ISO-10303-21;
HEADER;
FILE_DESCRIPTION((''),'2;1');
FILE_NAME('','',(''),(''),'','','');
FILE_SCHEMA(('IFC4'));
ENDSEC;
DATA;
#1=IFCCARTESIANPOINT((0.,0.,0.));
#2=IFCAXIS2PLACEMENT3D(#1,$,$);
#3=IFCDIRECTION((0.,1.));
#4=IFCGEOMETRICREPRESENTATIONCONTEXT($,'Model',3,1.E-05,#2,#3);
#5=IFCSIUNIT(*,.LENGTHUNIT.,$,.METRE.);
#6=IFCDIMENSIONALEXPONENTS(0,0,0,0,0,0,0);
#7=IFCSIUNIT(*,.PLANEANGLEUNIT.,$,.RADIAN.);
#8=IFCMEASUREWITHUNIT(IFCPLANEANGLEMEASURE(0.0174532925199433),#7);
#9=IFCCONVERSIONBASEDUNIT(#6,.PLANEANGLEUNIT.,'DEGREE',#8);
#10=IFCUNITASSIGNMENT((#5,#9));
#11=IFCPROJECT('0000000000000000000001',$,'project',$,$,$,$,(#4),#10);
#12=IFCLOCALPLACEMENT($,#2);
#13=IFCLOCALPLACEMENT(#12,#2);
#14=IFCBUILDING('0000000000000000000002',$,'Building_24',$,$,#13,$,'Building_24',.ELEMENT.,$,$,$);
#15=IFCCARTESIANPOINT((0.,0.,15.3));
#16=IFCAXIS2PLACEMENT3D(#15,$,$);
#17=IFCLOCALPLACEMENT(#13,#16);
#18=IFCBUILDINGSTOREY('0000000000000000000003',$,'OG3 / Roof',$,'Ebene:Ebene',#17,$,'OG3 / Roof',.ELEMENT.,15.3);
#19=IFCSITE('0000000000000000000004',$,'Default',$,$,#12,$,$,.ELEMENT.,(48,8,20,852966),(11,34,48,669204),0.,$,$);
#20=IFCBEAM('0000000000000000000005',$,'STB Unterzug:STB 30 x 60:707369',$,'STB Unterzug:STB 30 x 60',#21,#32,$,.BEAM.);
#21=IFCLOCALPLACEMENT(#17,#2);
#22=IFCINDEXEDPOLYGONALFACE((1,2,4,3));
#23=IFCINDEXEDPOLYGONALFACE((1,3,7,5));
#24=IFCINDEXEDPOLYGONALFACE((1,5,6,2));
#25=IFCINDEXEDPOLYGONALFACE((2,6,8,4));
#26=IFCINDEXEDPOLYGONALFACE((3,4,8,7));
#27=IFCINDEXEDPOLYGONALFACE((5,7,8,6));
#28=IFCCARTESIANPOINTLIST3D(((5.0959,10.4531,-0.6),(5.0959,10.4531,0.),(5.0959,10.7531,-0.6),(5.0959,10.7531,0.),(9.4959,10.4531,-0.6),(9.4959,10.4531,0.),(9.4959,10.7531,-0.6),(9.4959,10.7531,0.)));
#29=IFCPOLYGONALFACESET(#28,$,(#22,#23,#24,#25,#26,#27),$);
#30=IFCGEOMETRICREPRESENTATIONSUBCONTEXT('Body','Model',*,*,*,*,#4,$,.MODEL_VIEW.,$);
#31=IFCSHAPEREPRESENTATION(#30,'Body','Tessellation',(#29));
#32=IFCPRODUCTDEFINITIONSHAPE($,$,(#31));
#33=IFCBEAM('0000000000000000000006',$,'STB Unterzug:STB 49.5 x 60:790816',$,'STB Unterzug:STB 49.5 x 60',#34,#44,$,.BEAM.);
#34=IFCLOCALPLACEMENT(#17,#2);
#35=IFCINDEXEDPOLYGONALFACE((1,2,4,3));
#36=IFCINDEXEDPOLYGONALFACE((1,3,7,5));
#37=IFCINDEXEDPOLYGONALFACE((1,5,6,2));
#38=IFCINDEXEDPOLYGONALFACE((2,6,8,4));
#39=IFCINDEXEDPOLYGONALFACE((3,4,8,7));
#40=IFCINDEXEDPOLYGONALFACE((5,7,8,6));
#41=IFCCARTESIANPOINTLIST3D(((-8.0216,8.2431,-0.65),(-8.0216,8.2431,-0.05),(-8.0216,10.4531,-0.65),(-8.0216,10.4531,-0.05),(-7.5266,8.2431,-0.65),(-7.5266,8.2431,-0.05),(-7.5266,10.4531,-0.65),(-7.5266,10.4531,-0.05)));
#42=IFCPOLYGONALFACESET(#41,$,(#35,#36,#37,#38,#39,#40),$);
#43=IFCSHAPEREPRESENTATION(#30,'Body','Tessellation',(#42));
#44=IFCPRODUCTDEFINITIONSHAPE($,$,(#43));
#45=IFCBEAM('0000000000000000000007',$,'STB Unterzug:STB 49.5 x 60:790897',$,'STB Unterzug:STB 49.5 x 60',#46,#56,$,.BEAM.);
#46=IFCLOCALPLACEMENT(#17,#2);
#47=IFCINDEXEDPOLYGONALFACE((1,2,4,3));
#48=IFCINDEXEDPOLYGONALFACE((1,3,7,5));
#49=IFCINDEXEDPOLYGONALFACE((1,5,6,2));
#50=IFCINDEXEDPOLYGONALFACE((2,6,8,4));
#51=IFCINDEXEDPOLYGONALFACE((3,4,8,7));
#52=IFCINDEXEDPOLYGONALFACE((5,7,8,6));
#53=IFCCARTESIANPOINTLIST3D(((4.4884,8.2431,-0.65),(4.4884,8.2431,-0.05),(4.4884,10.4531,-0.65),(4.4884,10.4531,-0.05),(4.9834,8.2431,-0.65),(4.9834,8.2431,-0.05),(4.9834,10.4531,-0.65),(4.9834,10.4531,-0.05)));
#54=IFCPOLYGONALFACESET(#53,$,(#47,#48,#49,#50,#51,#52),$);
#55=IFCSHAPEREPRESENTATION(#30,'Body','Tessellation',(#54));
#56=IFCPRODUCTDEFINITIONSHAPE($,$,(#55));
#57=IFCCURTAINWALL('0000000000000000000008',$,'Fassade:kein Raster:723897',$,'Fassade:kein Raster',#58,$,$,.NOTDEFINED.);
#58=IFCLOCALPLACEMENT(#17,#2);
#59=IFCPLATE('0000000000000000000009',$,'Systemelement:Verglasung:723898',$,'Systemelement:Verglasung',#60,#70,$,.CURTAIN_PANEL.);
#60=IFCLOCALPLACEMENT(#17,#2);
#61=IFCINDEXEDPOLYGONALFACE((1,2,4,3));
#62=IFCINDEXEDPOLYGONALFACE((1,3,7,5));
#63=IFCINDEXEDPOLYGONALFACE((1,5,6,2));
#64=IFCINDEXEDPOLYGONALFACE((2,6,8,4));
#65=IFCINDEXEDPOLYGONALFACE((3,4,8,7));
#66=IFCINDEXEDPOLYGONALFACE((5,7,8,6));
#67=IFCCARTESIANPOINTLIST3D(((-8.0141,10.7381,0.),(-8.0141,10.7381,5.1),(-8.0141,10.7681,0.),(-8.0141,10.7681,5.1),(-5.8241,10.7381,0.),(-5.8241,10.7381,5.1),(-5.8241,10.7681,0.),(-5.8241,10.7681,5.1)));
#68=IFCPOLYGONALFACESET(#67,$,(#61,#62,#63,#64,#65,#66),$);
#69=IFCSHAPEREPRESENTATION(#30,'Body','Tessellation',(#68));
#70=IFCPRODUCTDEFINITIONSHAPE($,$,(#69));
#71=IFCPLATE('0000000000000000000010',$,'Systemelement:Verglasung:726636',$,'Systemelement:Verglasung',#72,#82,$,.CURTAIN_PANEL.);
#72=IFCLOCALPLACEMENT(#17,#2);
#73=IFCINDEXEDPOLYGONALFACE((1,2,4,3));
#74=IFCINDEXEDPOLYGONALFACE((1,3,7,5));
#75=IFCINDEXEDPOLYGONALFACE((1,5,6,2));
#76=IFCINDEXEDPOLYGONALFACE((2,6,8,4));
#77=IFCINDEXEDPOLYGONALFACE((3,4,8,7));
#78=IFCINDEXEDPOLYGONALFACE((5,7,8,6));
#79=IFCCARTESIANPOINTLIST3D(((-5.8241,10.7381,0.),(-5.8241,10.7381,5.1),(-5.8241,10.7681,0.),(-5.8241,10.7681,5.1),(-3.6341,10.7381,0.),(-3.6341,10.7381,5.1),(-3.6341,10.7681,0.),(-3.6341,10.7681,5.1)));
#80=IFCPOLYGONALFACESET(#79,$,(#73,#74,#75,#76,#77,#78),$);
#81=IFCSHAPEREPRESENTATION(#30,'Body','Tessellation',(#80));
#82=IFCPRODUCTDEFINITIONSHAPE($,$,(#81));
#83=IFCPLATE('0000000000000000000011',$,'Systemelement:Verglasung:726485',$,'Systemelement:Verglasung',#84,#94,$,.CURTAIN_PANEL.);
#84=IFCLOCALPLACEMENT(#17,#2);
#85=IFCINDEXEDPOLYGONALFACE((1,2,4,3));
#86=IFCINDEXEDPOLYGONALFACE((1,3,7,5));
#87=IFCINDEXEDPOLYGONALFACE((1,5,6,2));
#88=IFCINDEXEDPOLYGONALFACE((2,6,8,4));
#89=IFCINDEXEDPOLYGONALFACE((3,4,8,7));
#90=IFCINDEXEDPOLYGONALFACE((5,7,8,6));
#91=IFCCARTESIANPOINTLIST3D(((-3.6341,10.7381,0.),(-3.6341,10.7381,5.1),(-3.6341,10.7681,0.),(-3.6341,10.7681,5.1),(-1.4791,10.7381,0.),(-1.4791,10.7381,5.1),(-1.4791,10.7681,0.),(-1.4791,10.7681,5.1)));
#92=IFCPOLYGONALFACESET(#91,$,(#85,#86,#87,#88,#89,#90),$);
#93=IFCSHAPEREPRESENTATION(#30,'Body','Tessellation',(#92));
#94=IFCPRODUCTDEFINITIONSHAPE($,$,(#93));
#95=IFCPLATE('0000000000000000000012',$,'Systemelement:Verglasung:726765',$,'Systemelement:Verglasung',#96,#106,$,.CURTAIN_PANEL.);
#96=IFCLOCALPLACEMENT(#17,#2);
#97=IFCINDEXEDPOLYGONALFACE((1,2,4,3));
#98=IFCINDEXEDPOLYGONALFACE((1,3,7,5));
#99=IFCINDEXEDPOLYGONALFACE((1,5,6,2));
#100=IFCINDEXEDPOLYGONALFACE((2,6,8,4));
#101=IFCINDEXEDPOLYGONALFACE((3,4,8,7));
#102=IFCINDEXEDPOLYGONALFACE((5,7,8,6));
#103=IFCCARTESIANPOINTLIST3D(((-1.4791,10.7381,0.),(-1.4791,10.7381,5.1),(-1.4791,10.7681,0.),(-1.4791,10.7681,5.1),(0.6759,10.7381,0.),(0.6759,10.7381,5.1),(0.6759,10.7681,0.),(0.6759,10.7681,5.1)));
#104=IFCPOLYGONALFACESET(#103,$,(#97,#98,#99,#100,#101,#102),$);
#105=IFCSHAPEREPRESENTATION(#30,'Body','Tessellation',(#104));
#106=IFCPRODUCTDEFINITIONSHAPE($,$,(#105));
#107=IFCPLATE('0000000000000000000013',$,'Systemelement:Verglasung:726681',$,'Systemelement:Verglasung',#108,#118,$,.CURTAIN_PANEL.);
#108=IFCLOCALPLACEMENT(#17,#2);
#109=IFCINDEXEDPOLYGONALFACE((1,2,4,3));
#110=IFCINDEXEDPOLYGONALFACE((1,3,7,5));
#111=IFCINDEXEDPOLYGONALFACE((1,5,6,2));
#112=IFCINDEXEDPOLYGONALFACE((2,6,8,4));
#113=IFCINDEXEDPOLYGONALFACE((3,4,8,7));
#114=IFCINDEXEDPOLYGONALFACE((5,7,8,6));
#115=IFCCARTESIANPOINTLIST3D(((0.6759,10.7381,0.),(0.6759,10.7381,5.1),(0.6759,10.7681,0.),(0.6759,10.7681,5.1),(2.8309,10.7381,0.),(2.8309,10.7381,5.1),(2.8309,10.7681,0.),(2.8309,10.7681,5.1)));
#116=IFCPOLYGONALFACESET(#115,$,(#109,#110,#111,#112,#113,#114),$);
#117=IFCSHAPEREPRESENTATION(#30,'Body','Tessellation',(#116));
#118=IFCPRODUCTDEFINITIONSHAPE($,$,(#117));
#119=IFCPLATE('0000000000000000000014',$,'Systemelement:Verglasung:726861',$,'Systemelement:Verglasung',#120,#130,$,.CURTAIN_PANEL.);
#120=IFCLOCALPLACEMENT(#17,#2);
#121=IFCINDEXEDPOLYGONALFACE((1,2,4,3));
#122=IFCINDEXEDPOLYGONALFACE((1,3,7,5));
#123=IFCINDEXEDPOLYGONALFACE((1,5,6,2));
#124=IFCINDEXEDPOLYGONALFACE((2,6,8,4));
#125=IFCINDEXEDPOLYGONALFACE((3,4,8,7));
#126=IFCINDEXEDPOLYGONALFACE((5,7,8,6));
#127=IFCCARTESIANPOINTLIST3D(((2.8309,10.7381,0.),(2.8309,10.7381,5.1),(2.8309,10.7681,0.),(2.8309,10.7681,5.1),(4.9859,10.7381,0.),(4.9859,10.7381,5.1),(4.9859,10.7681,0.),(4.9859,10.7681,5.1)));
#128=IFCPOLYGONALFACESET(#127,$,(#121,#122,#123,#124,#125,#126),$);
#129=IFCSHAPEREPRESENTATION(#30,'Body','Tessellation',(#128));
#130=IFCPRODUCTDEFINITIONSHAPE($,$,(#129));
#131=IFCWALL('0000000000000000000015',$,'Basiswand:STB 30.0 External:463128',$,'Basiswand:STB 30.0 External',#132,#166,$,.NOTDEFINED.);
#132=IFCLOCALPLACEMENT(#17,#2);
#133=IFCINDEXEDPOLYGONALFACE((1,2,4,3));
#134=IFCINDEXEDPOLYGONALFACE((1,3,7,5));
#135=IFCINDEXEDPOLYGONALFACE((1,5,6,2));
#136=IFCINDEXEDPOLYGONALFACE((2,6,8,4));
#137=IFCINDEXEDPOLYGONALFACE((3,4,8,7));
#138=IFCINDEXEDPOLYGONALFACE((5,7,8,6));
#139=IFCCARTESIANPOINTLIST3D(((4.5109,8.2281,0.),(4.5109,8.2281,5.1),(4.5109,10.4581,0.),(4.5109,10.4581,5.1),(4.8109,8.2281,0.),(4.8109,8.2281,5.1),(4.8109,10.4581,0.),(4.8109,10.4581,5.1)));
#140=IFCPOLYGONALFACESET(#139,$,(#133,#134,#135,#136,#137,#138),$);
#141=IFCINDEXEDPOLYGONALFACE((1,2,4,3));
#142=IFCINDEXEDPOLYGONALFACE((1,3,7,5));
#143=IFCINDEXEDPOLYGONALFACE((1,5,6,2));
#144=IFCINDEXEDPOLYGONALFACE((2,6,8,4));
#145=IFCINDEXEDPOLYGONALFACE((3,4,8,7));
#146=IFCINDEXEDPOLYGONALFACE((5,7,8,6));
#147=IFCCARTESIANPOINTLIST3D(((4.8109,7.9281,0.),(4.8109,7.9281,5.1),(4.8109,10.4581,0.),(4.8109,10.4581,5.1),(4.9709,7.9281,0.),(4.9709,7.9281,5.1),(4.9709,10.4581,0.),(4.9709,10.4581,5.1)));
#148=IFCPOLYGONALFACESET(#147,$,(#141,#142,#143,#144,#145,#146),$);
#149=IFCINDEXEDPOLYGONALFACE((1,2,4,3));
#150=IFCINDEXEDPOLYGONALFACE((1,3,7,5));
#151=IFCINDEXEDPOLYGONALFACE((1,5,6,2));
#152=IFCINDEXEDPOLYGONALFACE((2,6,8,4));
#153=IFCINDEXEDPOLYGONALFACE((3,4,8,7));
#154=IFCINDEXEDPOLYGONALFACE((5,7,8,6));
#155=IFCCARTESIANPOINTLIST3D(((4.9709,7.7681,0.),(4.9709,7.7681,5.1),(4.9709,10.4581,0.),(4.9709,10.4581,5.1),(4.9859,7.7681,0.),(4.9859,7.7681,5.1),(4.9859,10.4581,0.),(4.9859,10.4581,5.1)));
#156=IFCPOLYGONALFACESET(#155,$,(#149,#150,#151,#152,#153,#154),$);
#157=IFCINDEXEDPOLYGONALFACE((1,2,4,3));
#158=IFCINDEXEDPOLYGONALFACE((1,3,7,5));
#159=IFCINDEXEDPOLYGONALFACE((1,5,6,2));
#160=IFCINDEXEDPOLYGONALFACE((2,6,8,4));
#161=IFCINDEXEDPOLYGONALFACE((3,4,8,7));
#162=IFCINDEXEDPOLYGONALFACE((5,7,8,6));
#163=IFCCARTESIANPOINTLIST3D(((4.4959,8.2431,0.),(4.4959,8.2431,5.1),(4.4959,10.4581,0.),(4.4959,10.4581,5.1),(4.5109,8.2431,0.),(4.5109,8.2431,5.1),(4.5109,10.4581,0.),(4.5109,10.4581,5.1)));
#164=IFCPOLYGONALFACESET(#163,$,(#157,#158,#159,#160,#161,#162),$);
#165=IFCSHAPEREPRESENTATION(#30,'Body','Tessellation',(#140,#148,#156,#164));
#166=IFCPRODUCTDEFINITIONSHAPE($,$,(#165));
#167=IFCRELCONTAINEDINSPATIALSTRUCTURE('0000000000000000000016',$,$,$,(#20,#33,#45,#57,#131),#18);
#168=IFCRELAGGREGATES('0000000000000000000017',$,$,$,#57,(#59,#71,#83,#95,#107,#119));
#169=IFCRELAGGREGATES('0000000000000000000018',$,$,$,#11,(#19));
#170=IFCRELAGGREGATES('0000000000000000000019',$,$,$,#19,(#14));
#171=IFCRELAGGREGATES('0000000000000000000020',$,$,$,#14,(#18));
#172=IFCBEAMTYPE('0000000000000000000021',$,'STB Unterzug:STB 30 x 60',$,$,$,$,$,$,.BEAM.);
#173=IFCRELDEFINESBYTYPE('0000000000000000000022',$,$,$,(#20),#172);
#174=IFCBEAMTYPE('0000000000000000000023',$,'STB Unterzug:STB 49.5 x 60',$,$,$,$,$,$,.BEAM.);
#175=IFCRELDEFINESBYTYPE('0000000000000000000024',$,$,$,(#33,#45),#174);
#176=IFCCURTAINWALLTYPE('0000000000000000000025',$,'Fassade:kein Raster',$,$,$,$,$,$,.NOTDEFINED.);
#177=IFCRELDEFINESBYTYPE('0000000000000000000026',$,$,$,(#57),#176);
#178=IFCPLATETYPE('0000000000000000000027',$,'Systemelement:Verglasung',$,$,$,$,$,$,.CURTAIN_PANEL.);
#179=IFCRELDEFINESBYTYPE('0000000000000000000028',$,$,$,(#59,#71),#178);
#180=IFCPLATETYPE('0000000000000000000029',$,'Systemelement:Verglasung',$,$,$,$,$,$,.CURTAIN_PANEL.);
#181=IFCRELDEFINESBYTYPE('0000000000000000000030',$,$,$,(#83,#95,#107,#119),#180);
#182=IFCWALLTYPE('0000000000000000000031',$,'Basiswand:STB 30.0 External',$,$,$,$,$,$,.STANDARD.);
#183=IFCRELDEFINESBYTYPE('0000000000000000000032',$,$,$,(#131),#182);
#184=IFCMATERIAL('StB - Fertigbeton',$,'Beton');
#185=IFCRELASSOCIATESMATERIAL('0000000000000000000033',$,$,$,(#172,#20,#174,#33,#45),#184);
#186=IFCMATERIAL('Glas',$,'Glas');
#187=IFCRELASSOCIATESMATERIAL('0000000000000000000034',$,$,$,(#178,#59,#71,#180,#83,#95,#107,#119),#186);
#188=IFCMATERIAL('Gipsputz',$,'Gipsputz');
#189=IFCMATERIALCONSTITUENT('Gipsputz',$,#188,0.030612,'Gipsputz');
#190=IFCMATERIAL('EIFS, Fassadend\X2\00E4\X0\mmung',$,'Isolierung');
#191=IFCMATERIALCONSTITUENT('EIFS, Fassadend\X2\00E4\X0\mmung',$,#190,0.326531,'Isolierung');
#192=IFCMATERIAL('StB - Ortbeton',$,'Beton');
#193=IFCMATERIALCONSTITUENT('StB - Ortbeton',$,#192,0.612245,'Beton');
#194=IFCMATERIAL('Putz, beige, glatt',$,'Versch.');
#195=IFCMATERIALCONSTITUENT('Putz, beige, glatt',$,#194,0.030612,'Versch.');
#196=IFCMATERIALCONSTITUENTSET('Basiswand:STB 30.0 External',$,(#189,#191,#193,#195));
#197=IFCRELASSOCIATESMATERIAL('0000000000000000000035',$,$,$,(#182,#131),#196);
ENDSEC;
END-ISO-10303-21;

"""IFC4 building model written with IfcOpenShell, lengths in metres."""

from ifc_helpers import new_model, entity, si_unit, converted_unit, direction, frame, origin, place, context, subcontext, project, spatial, indexed_curve, outline, extrude, source, transform, mapped, material, constituent, constituent_set, type_object, type_shapes, element, aggregate, save


model = new_model("IFC4")

# Units and contexts
model_context = context("Model", 3, precision=1e-05, world=origin(), true_north=direction((0.0, 1.0)))
body_context = subcontext(model_context, "Body", "Model", "MODEL_VIEW")
ifc_project = project(units=[si_unit("LENGTHUNIT", "METRE"), converted_unit("PLANEANGLEUNIT", "DEGREE", entity("IfcPlaneAngleMeasure", 0.0174532925199433), si_unit("PLANEANGLEUNIT", "RADIAN"), dimensions=[0, 0, 0, 0, 0, 0, 0])], contexts=[model_context])

# Site, building, storey
site_placement = place(None, origin())
site = spatial("IfcSite", under=ifc_project, at=site_placement, Name="Default", CompositionType="ELEMENT", RefLatitude=(48, 8, 20, 852966), RefLongitude=(11, 34, 48, 669204), RefElevation=0.0)
building_placement = place(site_placement, origin())
building = spatial("IfcBuilding", under=site, at=building_placement, Name="Building_24", LongName="Building_24", CompositionType="ELEMENT")
storey_placement = place(building_placement, frame((0.0, 0.0, 15.3)))
storey = spatial("IfcBuildingStorey", under=building, at=storey_placement, Name="OG3 / Roof", ObjectType="Ebene:Ebene", LongName="OG3 / Roof", CompositionType="ELEMENT", Elevation=15.3)

# Shared definitions
ifc_material_1 = material(Name="StB - Ortbeton", Category="Beton")

# Beams
ifc_material_2 = material(Name="StB - Fertigbeton", Category="Beton")
beam_type_1 = type_object("IfcBeamType", Name="STB Unterzug:STB 30 x 60", PredefinedType="BEAM", material=ifc_material_2)
shared_shape_1 = source(origin(), body_context, "Body", "SweptSolid", [
    extrude(outline(indexed_curve([(-2.2, -0.15), (2.2, -0.15), (2.2, 0.15), (-2.2, 0.15), (-2.2, -0.15)], self_intersect=False)), frame((-0.11, 0.0, -0.3), z_axis=(0.0, 0.0, 1.0), x_axis=(-1.0, 0.0, 0.0)), (0.0, 0.0, 1.0), 0.6),
])
type_shapes(beam_type_1, [shared_shape_1])
beam_1_placement = place(storey_placement, frame((7.4059, 10.6031, -0.3)))
element("IfcBeam", 1, at=beam_1_placement, inside=storey, type_object=beam_type_1, material=ifc_material_2, Name="STB Unterzug:STB 30 x 60:707369", ObjectType="STB Unterzug:STB 30 x 60", PredefinedType="BEAM", context=body_context, shape_type="MappedRepresentation", body=[
    mapped(shared_shape_1, transform((0.0, 0.0, 0.0), scale=1.0)),
])
beam_type_2 = type_object("IfcBeamType", Name="STB Unterzug:STB 49.5 x 60", PredefinedType="BEAM", material=ifc_material_2)
shared_shape_2 = source(origin(), body_context, "Body", "SweptSolid", [
    extrude(outline(indexed_curve([(-1.105, -0.2475), (1.105, -0.2475), (1.105, 0.2475), (-1.105, 0.2475), (-1.105, -0.2475)], self_intersect=False)), frame((-0.0475, 0.0, -0.3), z_axis=(0.0, 0.0, 1.0), x_axis=(-1.0, 0.0, 0.0)), (0.0, 0.0, 1.0), 0.6),
])
type_shapes(beam_type_2, [shared_shape_2])
for number, where, z_axis, x_axis, name in (
    (2, (-7.7741, 9.3006, -0.35), (0.0, 0.0, 1.0), (0.0, -1.0, 0.0), "STB Unterzug:STB 49.5 x 60:790816"),
    (3, (4.7359, 9.3006, -0.35), (0.0, 0.0, 1.0), (0.0, -1.0, 0.0), "STB Unterzug:STB 49.5 x 60:790897"),
):
    element("IfcBeam", number, at=place(storey_placement, frame(where, z_axis=z_axis, x_axis=x_axis)), inside=storey, type_object=beam_type_2, material=ifc_material_2, Name=name, ObjectType="STB Unterzug:STB 49.5 x 60", PredefinedType="BEAM", context=body_context, shape_type="MappedRepresentation", body=[
        mapped(shared_shape_2, transform((0.0, 0.0, 0.0), scale=1.0)),
    ])

# Curtain wall, plates
curtain_wall_type = type_object("IfcCurtainWallType", Name="Fassade:kein Raster", PredefinedType="NOTDEFINED")
curtain_wall_placement = place(storey_placement, frame((0.0, 0.0, -15.3)))
curtain_wall = element("IfcCurtainWall", 4, at=curtain_wall_placement, inside=storey, type_object=curtain_wall_type, Name="Fassade:kein Raster:723897", ObjectType="Fassade:kein Raster", PredefinedType="NOTDEFINED")
ifc_material_3 = material(Name="Glas", Category="Glas")
plate_type_1 = type_object("IfcPlateType", Name="Systemelement:Verglasung", PredefinedType="CURTAIN_PANEL", material=ifc_material_3)
shared_shape_3 = source(origin(), body_context, "Body", "SweptSolid", [
    extrude(outline(indexed_curve([(-0.015, -1.095), (0.015, -1.095), (0.015, 1.095), (-0.015, 1.095), (-0.015, -1.095)], self_intersect=False)), frame((0.0, 0.0, 0.0), z_axis=(0.0, 0.0, 1.0), x_axis=(0.0, 1.0, 0.0)), (0.0, 0.0, 1.0), 5.1),
])
type_shapes(plate_type_1, [shared_shape_3])
plate_1_placement = place(curtain_wall_placement, frame((-6.9191, 10.7531, 15.3)))
plate_1 = element("IfcPlate", 5, at=plate_1_placement, type_object=plate_type_1, material=ifc_material_3, Name="Systemelement:Verglasung:723898", ObjectType="Systemelement:Verglasung", PredefinedType="CURTAIN_PANEL", context=body_context, shape_type="MappedRepresentation", body=[
    mapped(shared_shape_3, transform((0.0, 0.0, 0.0), scale=1.0)),
])
plate_2_placement = place(curtain_wall_placement, frame((-4.7291, 10.7531, 15.3)))
plate_2 = element("IfcPlate", 6, at=plate_2_placement, type_object=plate_type_1, material=ifc_material_3, Name="Systemelement:Verglasung:726636", ObjectType="Systemelement:Verglasung", PredefinedType="CURTAIN_PANEL", context=body_context, shape_type="MappedRepresentation", body=[
    mapped(shared_shape_3, transform((0.0, 0.0, 0.0), scale=1.0)),
])
plate_type_2 = type_object("IfcPlateType", Name="Systemelement:Verglasung", PredefinedType="CURTAIN_PANEL", material=ifc_material_3)
shared_shape_4 = source(origin(), body_context, "Body", "SweptSolid", [
    extrude(outline(indexed_curve([(-0.015, -1.0775), (0.015, -1.0775), (0.015, 1.0775), (-0.015, 1.0775), (-0.015, -1.0775)], self_intersect=False)), frame((0.0, 0.0, 0.0), z_axis=(0.0, 0.0, 1.0), x_axis=(0.0, 1.0, 0.0)), (0.0, 0.0, 1.0), 5.1),
])
type_shapes(plate_type_2, [shared_shape_4])
plate_3_placement = place(curtain_wall_placement, frame((-2.5566, 10.7531, 15.3)))
plate_3 = element("IfcPlate", 7, at=plate_3_placement, type_object=plate_type_2, material=ifc_material_3, Name="Systemelement:Verglasung:726485", ObjectType="Systemelement:Verglasung", PredefinedType="CURTAIN_PANEL", context=body_context, shape_type="MappedRepresentation", body=[
    mapped(shared_shape_4, transform((0.0, 0.0, 0.0), scale=1.0)),
])
plate_4_placement = place(curtain_wall_placement, frame((-0.4016, 10.7531, 15.3)))
plate_4 = element("IfcPlate", 8, at=plate_4_placement, type_object=plate_type_2, material=ifc_material_3, Name="Systemelement:Verglasung:726765", ObjectType="Systemelement:Verglasung", PredefinedType="CURTAIN_PANEL", context=body_context, shape_type="MappedRepresentation", body=[
    mapped(shared_shape_4, transform((0.0, 0.0, 0.0), scale=1.0)),
])
plate_5_placement = place(curtain_wall_placement, frame((1.7534, 10.7531, 15.3)))
plate_5 = element("IfcPlate", 9, at=plate_5_placement, type_object=plate_type_2, material=ifc_material_3, Name="Systemelement:Verglasung:726681", ObjectType="Systemelement:Verglasung", PredefinedType="CURTAIN_PANEL", context=body_context, shape_type="MappedRepresentation", body=[
    mapped(shared_shape_4, transform((0.0, 0.0, 0.0), scale=1.0)),
])
plate_6_placement = place(curtain_wall_placement, frame((3.9084, 10.7531, 15.3)))
plate_6 = element("IfcPlate", 10, at=plate_6_placement, type_object=plate_type_2, material=ifc_material_3, Name="Systemelement:Verglasung:726861", ObjectType="Systemelement:Verglasung", PredefinedType="CURTAIN_PANEL", context=body_context, shape_type="MappedRepresentation", body=[
    mapped(shared_shape_4, transform((0.0, 0.0, 0.0), scale=1.0)),
])
aggregate(curtain_wall, [plate_1, plate_2, plate_3, plate_4, plate_5, plate_6])

# Wall
ifc_material_4 = material(Name="Gipsputz", Category="Gipsputz")
ifc_constituent_1 = constituent(ifc_material_4, Name="Gipsputz", Category="Gipsputz", fraction=0.030612)
ifc_material_5 = material(Name="EIFS, Fassadendämmung", Category="Isolierung")
ifc_constituent_2 = constituent(ifc_material_5, Name="EIFS, Fassadendämmung", Category="Isolierung", fraction=0.326531)
ifc_constituent_3 = constituent(ifc_material_1, Name="StB - Ortbeton", Category="Beton", fraction=0.612245)
ifc_material_6 = material(Name="Putz, beige, glatt", Category="Versch.")
ifc_constituent_4 = constituent(ifc_material_6, Name="Putz, beige, glatt", Category="Versch.", fraction=0.030612)
ifc_constituent_set_1 = constituent_set(constituents=[ifc_constituent_1, ifc_constituent_2, ifc_constituent_3, ifc_constituent_4], Name="Basiswand:STB 30.0 External")
wall_type = type_object("IfcWallType", Name="Basiswand:STB 30.0 External", PredefinedType="STANDARD", material=ifc_constituent_set_1)
wall_1_placement = place(storey_placement, frame((4.7409, 10.4581, 0.0), z_axis=(0.0, 0.0, 1.0), x_axis=(0.0, -1.0, 0.0)))
element("IfcWall", 11, at=wall_1_placement, inside=storey, type_object=wall_type, material=ifc_constituent_set_1, Name="Basiswand:STB 30.0 External:463128", ObjectType="Basiswand:STB 30.0 External", PredefinedType="NOTDEFINED", context=body_context, shape_type="SweptSolid", body=[
    extrude(outline(indexed_curve([(-1.115, -0.15), (1.115, -0.15), (1.115, 0.15), (-1.115, 0.15), (-1.115, -0.15)], self_intersect=False)), frame((1.115, -0.08, 0.0)), (0.0, 0.0, 1.0), 5.1),
    extrude(outline(indexed_curve([(-1.265, -0.08), (1.265, -0.08), (1.265, 0.08), (-1.265, 0.08), (-1.265, -0.08)], self_intersect=False)), frame((1.265, 0.15, 0.0)), (0.0, 0.0, 1.0), 5.1),
    extrude(outline(indexed_curve([(-0.0075, -1.345), (0.0075, -1.345), (0.0075, 1.345), (-0.0075, 1.345), (-0.0075, -1.345)], self_intersect=False)), frame((1.345, 0.2375, 0.0), z_axis=(0.0, 0.0, 1.0), x_axis=(0.0, -1.0, 0.0)), (0.0, 0.0, 1.0), 5.1),
    extrude(outline(indexed_curve([(-0.0075, -1.1075), (0.0075, -1.1075), (0.0075, 1.1075), (-0.0075, 1.1075), (-0.0075, -1.1075)], self_intersect=False)), frame((1.1075, -0.2375, 0.0), z_axis=(0.0, 0.0, 1.0), x_axis=(0.0, 1.0, 0.0)), (0.0, 0.0, 1.0), 5.1),
])

save(model, "model.ifc")
